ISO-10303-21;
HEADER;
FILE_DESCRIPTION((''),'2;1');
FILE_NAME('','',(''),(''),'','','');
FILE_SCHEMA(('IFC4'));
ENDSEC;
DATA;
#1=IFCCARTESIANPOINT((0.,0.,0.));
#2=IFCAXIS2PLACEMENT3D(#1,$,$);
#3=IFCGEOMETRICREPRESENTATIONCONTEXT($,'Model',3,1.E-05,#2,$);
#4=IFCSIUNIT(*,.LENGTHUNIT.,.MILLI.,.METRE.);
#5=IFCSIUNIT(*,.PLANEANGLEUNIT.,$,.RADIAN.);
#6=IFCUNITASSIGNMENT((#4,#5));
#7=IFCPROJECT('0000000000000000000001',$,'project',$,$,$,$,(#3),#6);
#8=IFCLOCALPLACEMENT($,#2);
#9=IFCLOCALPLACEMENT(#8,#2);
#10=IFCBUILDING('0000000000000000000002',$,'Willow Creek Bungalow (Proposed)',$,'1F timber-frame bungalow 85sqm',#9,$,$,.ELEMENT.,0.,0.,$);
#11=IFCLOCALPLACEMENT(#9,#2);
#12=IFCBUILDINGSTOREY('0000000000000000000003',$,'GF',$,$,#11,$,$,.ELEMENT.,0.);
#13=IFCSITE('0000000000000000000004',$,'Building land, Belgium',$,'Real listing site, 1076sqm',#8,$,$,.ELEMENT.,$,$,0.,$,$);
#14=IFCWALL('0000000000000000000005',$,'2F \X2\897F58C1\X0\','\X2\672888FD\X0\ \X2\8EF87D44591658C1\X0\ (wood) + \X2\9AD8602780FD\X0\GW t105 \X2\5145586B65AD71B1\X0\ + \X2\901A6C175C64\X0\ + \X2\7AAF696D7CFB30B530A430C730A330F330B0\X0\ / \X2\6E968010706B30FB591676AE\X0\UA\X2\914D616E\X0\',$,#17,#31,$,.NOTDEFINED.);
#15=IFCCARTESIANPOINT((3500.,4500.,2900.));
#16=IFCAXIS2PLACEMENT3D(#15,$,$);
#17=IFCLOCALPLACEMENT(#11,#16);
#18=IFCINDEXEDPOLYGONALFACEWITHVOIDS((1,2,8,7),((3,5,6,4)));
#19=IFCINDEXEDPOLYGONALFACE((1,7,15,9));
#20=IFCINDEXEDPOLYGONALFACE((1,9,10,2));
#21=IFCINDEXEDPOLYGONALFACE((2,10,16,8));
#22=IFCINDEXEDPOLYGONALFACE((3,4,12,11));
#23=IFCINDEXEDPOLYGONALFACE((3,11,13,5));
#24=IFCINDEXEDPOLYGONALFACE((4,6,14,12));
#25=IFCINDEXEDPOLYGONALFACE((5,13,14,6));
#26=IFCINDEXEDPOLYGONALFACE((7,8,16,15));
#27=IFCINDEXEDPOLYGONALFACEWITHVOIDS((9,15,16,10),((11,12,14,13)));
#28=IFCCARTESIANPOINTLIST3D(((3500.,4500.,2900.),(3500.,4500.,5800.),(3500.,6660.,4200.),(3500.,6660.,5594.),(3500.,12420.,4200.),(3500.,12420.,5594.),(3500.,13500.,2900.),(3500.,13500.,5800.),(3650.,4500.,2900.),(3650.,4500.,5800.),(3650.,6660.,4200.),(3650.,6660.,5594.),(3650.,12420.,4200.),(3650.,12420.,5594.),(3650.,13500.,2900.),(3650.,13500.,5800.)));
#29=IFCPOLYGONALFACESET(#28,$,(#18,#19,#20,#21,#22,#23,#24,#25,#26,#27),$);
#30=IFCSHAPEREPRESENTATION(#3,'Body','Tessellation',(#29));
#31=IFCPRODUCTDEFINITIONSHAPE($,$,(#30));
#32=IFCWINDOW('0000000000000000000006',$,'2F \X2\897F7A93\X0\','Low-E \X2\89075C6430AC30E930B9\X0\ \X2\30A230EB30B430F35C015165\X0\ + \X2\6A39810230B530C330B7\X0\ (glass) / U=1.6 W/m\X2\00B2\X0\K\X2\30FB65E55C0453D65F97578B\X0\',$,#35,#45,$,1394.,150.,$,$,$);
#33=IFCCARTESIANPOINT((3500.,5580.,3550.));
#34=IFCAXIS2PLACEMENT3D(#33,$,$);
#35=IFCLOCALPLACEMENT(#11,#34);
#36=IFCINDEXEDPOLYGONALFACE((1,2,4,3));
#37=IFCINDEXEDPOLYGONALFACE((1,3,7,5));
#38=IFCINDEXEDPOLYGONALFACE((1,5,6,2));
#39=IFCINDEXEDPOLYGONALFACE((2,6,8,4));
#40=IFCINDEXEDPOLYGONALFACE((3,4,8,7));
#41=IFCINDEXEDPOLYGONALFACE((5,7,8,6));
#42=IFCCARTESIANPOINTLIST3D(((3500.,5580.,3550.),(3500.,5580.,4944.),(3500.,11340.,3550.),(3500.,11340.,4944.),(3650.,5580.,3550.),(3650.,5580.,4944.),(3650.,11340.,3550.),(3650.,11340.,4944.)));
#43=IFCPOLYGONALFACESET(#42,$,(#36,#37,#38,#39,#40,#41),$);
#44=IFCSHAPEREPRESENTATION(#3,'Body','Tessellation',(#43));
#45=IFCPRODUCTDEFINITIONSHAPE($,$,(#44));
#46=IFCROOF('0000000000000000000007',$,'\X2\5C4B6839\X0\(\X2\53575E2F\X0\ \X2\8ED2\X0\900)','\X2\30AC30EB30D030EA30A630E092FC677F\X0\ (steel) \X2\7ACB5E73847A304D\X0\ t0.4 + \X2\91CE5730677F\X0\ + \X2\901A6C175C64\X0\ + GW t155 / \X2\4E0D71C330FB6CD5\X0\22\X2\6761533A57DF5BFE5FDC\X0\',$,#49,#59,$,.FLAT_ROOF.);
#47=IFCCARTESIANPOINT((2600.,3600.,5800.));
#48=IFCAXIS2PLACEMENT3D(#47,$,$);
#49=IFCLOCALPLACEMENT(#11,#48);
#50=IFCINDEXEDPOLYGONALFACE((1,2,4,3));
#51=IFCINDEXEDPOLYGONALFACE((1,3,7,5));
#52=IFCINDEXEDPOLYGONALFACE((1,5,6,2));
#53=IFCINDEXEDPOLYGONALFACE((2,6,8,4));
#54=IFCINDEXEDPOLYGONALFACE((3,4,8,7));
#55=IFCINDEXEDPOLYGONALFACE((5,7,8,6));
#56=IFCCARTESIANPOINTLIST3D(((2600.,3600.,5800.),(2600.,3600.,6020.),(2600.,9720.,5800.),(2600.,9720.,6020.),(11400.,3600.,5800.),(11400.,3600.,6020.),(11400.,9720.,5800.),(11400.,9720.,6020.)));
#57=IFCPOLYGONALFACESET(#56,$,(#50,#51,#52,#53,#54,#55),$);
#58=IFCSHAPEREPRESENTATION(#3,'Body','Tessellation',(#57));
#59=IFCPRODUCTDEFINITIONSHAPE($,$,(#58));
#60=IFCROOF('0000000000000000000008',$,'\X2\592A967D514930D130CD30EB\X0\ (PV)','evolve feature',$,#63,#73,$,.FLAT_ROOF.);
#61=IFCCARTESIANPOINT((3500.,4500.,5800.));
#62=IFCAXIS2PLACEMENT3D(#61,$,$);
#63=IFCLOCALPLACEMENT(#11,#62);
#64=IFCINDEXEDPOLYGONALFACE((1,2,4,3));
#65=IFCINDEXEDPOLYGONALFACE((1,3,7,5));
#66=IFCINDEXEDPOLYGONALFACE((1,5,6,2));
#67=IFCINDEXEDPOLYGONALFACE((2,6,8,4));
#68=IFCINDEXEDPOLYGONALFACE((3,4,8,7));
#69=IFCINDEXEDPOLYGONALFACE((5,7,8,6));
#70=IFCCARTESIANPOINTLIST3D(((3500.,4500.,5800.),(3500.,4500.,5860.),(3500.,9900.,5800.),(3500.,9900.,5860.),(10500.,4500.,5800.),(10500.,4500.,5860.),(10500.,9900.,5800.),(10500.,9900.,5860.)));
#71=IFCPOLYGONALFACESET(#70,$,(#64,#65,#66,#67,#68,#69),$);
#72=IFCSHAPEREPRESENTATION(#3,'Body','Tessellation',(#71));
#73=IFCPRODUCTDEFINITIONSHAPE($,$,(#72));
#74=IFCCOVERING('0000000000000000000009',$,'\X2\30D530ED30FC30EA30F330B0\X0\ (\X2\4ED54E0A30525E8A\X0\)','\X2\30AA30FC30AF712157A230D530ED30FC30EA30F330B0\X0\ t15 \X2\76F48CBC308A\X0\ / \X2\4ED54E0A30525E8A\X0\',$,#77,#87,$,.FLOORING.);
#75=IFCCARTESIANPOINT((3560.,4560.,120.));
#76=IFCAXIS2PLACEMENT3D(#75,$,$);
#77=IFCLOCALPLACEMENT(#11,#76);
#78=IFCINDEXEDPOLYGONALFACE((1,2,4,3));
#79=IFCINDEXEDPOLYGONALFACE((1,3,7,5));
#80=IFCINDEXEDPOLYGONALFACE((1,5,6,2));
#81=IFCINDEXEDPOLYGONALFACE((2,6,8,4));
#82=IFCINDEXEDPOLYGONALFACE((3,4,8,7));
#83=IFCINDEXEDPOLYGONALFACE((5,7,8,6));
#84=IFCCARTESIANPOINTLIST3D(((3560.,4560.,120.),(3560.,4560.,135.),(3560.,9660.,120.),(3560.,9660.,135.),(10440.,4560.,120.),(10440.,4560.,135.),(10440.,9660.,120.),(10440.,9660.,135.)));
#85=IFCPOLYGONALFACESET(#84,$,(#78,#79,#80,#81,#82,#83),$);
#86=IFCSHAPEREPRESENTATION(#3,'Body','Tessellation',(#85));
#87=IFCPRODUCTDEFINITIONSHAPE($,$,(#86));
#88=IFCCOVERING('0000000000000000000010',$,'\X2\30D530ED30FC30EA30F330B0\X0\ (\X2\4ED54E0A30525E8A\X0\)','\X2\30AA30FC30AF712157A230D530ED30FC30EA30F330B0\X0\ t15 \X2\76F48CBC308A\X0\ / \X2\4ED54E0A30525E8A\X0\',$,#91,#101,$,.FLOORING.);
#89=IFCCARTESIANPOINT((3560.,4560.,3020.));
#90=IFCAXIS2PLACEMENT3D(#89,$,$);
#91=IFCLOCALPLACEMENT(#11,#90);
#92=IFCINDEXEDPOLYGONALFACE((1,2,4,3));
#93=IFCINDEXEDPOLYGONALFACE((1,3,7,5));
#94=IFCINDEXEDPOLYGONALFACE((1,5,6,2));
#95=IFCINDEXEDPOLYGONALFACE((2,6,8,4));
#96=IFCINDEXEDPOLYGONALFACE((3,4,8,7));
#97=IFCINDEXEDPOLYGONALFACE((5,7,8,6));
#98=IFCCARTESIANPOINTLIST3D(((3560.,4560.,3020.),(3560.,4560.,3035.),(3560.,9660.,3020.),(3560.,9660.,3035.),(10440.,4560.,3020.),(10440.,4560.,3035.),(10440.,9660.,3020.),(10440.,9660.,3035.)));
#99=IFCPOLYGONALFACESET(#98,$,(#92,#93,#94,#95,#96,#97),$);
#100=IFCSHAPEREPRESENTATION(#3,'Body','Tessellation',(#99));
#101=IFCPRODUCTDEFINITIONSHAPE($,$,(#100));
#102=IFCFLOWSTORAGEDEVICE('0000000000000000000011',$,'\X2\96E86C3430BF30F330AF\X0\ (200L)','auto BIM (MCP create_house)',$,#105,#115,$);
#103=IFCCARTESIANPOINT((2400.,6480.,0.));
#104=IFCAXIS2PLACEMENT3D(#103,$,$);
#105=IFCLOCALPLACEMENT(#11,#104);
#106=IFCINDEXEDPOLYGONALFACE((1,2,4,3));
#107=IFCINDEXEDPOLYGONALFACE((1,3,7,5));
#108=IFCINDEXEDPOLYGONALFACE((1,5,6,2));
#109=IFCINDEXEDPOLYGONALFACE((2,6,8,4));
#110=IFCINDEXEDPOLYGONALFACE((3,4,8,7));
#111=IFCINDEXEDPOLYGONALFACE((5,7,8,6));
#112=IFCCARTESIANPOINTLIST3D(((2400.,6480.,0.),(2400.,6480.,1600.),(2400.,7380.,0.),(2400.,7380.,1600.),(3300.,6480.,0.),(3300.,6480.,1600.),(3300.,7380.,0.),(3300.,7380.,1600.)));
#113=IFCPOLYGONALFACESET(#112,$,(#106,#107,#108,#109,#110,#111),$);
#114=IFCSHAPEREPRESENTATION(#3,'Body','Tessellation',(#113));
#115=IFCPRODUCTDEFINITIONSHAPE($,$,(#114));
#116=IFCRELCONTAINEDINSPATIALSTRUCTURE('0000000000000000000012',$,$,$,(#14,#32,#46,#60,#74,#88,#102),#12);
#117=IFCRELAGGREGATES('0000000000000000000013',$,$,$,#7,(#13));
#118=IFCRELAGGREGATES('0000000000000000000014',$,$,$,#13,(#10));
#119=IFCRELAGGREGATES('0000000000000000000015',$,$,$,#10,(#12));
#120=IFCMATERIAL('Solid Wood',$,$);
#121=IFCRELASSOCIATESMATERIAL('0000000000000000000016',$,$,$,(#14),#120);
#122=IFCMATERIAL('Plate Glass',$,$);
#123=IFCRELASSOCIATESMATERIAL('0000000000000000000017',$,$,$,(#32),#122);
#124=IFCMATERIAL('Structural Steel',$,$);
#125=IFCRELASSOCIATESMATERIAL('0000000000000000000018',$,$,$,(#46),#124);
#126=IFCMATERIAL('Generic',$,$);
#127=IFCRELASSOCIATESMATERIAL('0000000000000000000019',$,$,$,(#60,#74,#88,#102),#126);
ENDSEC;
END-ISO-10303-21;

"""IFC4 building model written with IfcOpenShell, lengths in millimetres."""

from ifc_helpers import new_model, si_unit, frame, frame_2d, origin, place, context, project, spatial, rectangle, extrude, material, element, fill, save


model = new_model("IFC4")

# Units and contexts
model_context = context("Model", 3, precision=1e-05, world=origin())
ifc_project = project(units=[si_unit("LENGTHUNIT", "METRE", prefix="MILLI"), si_unit("PLANEANGLEUNIT", "RADIAN")], contexts=[model_context])

# Site, building, storey
site_placement = place(None, origin())
site = spatial("IfcSite", under=ifc_project, at=site_placement, Name="Building land, Belgium", ObjectType="Real listing site, 1076sqm", CompositionType="ELEMENT", RefElevation=0.0)
building_placement = place(site_placement, origin())
building = spatial("IfcBuilding", under=site, at=building_placement, Name="Willow Creek Bungalow (Proposed)", ObjectType="1F timber-frame bungalow 85sqm", CompositionType="ELEMENT", ElevationOfRefHeight=0.0, ElevationOfTerrain=0.0)
storey_placement = place(building_placement, origin())
storey = spatial("IfcBuildingStorey", under=building, at=storey_placement, Name="GF", CompositionType="ELEMENT", Elevation=0.0)

# Shared definitions
ifc_material_1 = material(Name="Solid Wood")
ifc_material_2 = material(Name="Generic")

# Shared definitions
ifc_material_3 = material(Name="Plate Glass")

# Wall, opening, window
wall_1_placement = place(storey_placement, frame((3500.0, 4500.0, 2900.0)))
wall_1 = element("IfcWall", 1, at=wall_1_placement, inside=storey, material=ifc_material_1, Name="2F 西壁", Description="木製 軸組外壁 (wood) + 高性能GW t105 充填断熱 + 通気層 + 窯業系サイディング / 準耐火・外皮UA配慮", PredefinedType="NOTDEFINED", context=model_context, shape_type="SweptSolid", body=[
    extrude(rectangle(XDim=150.0, YDim=9000.0, at=frame_2d((75.0, 4500.0))), frame((3500.0, 4500.0, 2900.0)), (0.0, 0.0, 1.0), 2900.0),
])
opening_1_placement = place(storey_placement, frame((3500.0, 5580.0, 3550.0)))
opening_1 = element("IfcOpeningElement", 2, at=opening_1_placement, cuts=wall_1, PredefinedType="NOTDEFINED", context=model_context, shape_type="SweptSolid", body=[
    extrude(rectangle(XDim=150.0, YDim=5760.0, at=frame_2d((75.0, 2880.0))), frame((3500.0, 5580.0, 3550.0)), (0.0, 0.0, 1.0), 1394.0),
])
window_1_placement = place(storey_placement, frame((3500.0, 5580.0, 3550.0)))
window_1 = element("IfcWindow", 3, at=window_1_placement, inside=storey, material=ifc_material_3, Name="2F 西窓", Description="Low-E 複層ガラス アルゴン封入 + 樹脂サッシ (glass) / U=1.6 W/m²K・日射取得型", OverallHeight=1394.0, OverallWidth=150.0, context=model_context, shape_type="SweptSolid", body=[
    extrude(rectangle(XDim=150.0, YDim=5760.0, at=frame_2d((75.0, 2880.0))), frame((3500.0, 5580.0, 3550.0)), (0.0, 0.0, 1.0), 1394.0),
])
fill(opening_1, window_1)

# Roofs
ifc_material_4 = material(Name="Structural Steel")
for number, where, name in (
    (4, (2600.0, 3600.0, 5800.0), "屋根(南帯 軒900)"),
):
    element("IfcRoof", number, at=place(storey_placement, frame(where)), inside=storey, material=ifc_material_4, Name=name, Description="ガルバリウム鋼板 (steel) 立平葺き t0.4 + 野地板 + 通気層 + GW t155 / 不燃・法22条区域対応", PredefinedType="FLAT_ROOF", context=model_context, shape_type="SweptSolid", body=[
        extrude(rectangle(XDim=8800.0, YDim=6120.0, at=frame_2d((4400.0, 3060.0))), frame((2600.0, 3600.0, 5800.0)), (0.0, 0.0, 1.0), 220.0),
    ])
roof_placement = place(storey_placement, frame((3500.0, 4500.0, 5800.0)))
element("IfcRoof", 5, at=roof_placement, inside=storey, material=ifc_material_2, Name="太陽光パネル (PV)", Description="evolve feature", PredefinedType="FLAT_ROOF", context=model_context, shape_type="SweptSolid", body=[
    extrude(rectangle(XDim=7000.0, YDim=5400.0, at=frame_2d((3500.0, 2700.0))), frame((3500.0, 4500.0, 5800.0)), (0.0, 0.0, 1.0), 60.0),
])

# Coverings
covering_1_placement = place(storey_placement, frame((3560.0, 4560.0, 120.0)))
element("IfcCovering", 6, at=covering_1_placement, inside=storey, material=ifc_material_2, Name="フローリング (仕上げ床)", Description="オーク無垢フローリング t15 直貼り / 仕上げ床", PredefinedType="FLOORING", context=model_context, shape_type="SweptSolid", body=[
    extrude(rectangle(XDim=6880.0, YDim=5100.0, at=frame_2d((3440.0, 2550.0))), frame((3560.0, 4560.0, 120.0)), (0.0, 0.0, 1.0), 15.0),
])
covering_2_placement = place(storey_placement, frame((3560.0, 4560.0, 3020.0)))
element("IfcCovering", 7, at=covering_2_placement, inside=storey, material=ifc_material_2, Name="フローリング (仕上げ床)", Description="オーク無垢フローリング t15 直貼り / 仕上げ床", PredefinedType="FLOORING", context=model_context, shape_type="SweptSolid", body=[
    extrude(rectangle(XDim=6880.0, YDim=5100.0, at=frame_2d((3440.0, 2550.0))), frame((3560.0, 4560.0, 3020.0)), (0.0, 0.0, 1.0), 15.0),
])

# Flow storage device
flow_storage_device_placement = place(storey_placement, frame((2400.0, 6480.0, 0.0)))
element("IfcFlowStorageDevice", 8, at=flow_storage_device_placement, inside=storey, material=ifc_material_2, Name="雨水タンク (200L)", Description="auto BIM (MCP create_house)", context=model_context, shape_type="SweptSolid", body=[
    extrude(rectangle(XDim=900.0, YDim=900.0, at=frame_2d((450.0, 450.0))), frame((2400.0, 6480.0, 0.0)), (0.0, 0.0, 1.0), 1600.0),
])

save(model, "model.ifc")
